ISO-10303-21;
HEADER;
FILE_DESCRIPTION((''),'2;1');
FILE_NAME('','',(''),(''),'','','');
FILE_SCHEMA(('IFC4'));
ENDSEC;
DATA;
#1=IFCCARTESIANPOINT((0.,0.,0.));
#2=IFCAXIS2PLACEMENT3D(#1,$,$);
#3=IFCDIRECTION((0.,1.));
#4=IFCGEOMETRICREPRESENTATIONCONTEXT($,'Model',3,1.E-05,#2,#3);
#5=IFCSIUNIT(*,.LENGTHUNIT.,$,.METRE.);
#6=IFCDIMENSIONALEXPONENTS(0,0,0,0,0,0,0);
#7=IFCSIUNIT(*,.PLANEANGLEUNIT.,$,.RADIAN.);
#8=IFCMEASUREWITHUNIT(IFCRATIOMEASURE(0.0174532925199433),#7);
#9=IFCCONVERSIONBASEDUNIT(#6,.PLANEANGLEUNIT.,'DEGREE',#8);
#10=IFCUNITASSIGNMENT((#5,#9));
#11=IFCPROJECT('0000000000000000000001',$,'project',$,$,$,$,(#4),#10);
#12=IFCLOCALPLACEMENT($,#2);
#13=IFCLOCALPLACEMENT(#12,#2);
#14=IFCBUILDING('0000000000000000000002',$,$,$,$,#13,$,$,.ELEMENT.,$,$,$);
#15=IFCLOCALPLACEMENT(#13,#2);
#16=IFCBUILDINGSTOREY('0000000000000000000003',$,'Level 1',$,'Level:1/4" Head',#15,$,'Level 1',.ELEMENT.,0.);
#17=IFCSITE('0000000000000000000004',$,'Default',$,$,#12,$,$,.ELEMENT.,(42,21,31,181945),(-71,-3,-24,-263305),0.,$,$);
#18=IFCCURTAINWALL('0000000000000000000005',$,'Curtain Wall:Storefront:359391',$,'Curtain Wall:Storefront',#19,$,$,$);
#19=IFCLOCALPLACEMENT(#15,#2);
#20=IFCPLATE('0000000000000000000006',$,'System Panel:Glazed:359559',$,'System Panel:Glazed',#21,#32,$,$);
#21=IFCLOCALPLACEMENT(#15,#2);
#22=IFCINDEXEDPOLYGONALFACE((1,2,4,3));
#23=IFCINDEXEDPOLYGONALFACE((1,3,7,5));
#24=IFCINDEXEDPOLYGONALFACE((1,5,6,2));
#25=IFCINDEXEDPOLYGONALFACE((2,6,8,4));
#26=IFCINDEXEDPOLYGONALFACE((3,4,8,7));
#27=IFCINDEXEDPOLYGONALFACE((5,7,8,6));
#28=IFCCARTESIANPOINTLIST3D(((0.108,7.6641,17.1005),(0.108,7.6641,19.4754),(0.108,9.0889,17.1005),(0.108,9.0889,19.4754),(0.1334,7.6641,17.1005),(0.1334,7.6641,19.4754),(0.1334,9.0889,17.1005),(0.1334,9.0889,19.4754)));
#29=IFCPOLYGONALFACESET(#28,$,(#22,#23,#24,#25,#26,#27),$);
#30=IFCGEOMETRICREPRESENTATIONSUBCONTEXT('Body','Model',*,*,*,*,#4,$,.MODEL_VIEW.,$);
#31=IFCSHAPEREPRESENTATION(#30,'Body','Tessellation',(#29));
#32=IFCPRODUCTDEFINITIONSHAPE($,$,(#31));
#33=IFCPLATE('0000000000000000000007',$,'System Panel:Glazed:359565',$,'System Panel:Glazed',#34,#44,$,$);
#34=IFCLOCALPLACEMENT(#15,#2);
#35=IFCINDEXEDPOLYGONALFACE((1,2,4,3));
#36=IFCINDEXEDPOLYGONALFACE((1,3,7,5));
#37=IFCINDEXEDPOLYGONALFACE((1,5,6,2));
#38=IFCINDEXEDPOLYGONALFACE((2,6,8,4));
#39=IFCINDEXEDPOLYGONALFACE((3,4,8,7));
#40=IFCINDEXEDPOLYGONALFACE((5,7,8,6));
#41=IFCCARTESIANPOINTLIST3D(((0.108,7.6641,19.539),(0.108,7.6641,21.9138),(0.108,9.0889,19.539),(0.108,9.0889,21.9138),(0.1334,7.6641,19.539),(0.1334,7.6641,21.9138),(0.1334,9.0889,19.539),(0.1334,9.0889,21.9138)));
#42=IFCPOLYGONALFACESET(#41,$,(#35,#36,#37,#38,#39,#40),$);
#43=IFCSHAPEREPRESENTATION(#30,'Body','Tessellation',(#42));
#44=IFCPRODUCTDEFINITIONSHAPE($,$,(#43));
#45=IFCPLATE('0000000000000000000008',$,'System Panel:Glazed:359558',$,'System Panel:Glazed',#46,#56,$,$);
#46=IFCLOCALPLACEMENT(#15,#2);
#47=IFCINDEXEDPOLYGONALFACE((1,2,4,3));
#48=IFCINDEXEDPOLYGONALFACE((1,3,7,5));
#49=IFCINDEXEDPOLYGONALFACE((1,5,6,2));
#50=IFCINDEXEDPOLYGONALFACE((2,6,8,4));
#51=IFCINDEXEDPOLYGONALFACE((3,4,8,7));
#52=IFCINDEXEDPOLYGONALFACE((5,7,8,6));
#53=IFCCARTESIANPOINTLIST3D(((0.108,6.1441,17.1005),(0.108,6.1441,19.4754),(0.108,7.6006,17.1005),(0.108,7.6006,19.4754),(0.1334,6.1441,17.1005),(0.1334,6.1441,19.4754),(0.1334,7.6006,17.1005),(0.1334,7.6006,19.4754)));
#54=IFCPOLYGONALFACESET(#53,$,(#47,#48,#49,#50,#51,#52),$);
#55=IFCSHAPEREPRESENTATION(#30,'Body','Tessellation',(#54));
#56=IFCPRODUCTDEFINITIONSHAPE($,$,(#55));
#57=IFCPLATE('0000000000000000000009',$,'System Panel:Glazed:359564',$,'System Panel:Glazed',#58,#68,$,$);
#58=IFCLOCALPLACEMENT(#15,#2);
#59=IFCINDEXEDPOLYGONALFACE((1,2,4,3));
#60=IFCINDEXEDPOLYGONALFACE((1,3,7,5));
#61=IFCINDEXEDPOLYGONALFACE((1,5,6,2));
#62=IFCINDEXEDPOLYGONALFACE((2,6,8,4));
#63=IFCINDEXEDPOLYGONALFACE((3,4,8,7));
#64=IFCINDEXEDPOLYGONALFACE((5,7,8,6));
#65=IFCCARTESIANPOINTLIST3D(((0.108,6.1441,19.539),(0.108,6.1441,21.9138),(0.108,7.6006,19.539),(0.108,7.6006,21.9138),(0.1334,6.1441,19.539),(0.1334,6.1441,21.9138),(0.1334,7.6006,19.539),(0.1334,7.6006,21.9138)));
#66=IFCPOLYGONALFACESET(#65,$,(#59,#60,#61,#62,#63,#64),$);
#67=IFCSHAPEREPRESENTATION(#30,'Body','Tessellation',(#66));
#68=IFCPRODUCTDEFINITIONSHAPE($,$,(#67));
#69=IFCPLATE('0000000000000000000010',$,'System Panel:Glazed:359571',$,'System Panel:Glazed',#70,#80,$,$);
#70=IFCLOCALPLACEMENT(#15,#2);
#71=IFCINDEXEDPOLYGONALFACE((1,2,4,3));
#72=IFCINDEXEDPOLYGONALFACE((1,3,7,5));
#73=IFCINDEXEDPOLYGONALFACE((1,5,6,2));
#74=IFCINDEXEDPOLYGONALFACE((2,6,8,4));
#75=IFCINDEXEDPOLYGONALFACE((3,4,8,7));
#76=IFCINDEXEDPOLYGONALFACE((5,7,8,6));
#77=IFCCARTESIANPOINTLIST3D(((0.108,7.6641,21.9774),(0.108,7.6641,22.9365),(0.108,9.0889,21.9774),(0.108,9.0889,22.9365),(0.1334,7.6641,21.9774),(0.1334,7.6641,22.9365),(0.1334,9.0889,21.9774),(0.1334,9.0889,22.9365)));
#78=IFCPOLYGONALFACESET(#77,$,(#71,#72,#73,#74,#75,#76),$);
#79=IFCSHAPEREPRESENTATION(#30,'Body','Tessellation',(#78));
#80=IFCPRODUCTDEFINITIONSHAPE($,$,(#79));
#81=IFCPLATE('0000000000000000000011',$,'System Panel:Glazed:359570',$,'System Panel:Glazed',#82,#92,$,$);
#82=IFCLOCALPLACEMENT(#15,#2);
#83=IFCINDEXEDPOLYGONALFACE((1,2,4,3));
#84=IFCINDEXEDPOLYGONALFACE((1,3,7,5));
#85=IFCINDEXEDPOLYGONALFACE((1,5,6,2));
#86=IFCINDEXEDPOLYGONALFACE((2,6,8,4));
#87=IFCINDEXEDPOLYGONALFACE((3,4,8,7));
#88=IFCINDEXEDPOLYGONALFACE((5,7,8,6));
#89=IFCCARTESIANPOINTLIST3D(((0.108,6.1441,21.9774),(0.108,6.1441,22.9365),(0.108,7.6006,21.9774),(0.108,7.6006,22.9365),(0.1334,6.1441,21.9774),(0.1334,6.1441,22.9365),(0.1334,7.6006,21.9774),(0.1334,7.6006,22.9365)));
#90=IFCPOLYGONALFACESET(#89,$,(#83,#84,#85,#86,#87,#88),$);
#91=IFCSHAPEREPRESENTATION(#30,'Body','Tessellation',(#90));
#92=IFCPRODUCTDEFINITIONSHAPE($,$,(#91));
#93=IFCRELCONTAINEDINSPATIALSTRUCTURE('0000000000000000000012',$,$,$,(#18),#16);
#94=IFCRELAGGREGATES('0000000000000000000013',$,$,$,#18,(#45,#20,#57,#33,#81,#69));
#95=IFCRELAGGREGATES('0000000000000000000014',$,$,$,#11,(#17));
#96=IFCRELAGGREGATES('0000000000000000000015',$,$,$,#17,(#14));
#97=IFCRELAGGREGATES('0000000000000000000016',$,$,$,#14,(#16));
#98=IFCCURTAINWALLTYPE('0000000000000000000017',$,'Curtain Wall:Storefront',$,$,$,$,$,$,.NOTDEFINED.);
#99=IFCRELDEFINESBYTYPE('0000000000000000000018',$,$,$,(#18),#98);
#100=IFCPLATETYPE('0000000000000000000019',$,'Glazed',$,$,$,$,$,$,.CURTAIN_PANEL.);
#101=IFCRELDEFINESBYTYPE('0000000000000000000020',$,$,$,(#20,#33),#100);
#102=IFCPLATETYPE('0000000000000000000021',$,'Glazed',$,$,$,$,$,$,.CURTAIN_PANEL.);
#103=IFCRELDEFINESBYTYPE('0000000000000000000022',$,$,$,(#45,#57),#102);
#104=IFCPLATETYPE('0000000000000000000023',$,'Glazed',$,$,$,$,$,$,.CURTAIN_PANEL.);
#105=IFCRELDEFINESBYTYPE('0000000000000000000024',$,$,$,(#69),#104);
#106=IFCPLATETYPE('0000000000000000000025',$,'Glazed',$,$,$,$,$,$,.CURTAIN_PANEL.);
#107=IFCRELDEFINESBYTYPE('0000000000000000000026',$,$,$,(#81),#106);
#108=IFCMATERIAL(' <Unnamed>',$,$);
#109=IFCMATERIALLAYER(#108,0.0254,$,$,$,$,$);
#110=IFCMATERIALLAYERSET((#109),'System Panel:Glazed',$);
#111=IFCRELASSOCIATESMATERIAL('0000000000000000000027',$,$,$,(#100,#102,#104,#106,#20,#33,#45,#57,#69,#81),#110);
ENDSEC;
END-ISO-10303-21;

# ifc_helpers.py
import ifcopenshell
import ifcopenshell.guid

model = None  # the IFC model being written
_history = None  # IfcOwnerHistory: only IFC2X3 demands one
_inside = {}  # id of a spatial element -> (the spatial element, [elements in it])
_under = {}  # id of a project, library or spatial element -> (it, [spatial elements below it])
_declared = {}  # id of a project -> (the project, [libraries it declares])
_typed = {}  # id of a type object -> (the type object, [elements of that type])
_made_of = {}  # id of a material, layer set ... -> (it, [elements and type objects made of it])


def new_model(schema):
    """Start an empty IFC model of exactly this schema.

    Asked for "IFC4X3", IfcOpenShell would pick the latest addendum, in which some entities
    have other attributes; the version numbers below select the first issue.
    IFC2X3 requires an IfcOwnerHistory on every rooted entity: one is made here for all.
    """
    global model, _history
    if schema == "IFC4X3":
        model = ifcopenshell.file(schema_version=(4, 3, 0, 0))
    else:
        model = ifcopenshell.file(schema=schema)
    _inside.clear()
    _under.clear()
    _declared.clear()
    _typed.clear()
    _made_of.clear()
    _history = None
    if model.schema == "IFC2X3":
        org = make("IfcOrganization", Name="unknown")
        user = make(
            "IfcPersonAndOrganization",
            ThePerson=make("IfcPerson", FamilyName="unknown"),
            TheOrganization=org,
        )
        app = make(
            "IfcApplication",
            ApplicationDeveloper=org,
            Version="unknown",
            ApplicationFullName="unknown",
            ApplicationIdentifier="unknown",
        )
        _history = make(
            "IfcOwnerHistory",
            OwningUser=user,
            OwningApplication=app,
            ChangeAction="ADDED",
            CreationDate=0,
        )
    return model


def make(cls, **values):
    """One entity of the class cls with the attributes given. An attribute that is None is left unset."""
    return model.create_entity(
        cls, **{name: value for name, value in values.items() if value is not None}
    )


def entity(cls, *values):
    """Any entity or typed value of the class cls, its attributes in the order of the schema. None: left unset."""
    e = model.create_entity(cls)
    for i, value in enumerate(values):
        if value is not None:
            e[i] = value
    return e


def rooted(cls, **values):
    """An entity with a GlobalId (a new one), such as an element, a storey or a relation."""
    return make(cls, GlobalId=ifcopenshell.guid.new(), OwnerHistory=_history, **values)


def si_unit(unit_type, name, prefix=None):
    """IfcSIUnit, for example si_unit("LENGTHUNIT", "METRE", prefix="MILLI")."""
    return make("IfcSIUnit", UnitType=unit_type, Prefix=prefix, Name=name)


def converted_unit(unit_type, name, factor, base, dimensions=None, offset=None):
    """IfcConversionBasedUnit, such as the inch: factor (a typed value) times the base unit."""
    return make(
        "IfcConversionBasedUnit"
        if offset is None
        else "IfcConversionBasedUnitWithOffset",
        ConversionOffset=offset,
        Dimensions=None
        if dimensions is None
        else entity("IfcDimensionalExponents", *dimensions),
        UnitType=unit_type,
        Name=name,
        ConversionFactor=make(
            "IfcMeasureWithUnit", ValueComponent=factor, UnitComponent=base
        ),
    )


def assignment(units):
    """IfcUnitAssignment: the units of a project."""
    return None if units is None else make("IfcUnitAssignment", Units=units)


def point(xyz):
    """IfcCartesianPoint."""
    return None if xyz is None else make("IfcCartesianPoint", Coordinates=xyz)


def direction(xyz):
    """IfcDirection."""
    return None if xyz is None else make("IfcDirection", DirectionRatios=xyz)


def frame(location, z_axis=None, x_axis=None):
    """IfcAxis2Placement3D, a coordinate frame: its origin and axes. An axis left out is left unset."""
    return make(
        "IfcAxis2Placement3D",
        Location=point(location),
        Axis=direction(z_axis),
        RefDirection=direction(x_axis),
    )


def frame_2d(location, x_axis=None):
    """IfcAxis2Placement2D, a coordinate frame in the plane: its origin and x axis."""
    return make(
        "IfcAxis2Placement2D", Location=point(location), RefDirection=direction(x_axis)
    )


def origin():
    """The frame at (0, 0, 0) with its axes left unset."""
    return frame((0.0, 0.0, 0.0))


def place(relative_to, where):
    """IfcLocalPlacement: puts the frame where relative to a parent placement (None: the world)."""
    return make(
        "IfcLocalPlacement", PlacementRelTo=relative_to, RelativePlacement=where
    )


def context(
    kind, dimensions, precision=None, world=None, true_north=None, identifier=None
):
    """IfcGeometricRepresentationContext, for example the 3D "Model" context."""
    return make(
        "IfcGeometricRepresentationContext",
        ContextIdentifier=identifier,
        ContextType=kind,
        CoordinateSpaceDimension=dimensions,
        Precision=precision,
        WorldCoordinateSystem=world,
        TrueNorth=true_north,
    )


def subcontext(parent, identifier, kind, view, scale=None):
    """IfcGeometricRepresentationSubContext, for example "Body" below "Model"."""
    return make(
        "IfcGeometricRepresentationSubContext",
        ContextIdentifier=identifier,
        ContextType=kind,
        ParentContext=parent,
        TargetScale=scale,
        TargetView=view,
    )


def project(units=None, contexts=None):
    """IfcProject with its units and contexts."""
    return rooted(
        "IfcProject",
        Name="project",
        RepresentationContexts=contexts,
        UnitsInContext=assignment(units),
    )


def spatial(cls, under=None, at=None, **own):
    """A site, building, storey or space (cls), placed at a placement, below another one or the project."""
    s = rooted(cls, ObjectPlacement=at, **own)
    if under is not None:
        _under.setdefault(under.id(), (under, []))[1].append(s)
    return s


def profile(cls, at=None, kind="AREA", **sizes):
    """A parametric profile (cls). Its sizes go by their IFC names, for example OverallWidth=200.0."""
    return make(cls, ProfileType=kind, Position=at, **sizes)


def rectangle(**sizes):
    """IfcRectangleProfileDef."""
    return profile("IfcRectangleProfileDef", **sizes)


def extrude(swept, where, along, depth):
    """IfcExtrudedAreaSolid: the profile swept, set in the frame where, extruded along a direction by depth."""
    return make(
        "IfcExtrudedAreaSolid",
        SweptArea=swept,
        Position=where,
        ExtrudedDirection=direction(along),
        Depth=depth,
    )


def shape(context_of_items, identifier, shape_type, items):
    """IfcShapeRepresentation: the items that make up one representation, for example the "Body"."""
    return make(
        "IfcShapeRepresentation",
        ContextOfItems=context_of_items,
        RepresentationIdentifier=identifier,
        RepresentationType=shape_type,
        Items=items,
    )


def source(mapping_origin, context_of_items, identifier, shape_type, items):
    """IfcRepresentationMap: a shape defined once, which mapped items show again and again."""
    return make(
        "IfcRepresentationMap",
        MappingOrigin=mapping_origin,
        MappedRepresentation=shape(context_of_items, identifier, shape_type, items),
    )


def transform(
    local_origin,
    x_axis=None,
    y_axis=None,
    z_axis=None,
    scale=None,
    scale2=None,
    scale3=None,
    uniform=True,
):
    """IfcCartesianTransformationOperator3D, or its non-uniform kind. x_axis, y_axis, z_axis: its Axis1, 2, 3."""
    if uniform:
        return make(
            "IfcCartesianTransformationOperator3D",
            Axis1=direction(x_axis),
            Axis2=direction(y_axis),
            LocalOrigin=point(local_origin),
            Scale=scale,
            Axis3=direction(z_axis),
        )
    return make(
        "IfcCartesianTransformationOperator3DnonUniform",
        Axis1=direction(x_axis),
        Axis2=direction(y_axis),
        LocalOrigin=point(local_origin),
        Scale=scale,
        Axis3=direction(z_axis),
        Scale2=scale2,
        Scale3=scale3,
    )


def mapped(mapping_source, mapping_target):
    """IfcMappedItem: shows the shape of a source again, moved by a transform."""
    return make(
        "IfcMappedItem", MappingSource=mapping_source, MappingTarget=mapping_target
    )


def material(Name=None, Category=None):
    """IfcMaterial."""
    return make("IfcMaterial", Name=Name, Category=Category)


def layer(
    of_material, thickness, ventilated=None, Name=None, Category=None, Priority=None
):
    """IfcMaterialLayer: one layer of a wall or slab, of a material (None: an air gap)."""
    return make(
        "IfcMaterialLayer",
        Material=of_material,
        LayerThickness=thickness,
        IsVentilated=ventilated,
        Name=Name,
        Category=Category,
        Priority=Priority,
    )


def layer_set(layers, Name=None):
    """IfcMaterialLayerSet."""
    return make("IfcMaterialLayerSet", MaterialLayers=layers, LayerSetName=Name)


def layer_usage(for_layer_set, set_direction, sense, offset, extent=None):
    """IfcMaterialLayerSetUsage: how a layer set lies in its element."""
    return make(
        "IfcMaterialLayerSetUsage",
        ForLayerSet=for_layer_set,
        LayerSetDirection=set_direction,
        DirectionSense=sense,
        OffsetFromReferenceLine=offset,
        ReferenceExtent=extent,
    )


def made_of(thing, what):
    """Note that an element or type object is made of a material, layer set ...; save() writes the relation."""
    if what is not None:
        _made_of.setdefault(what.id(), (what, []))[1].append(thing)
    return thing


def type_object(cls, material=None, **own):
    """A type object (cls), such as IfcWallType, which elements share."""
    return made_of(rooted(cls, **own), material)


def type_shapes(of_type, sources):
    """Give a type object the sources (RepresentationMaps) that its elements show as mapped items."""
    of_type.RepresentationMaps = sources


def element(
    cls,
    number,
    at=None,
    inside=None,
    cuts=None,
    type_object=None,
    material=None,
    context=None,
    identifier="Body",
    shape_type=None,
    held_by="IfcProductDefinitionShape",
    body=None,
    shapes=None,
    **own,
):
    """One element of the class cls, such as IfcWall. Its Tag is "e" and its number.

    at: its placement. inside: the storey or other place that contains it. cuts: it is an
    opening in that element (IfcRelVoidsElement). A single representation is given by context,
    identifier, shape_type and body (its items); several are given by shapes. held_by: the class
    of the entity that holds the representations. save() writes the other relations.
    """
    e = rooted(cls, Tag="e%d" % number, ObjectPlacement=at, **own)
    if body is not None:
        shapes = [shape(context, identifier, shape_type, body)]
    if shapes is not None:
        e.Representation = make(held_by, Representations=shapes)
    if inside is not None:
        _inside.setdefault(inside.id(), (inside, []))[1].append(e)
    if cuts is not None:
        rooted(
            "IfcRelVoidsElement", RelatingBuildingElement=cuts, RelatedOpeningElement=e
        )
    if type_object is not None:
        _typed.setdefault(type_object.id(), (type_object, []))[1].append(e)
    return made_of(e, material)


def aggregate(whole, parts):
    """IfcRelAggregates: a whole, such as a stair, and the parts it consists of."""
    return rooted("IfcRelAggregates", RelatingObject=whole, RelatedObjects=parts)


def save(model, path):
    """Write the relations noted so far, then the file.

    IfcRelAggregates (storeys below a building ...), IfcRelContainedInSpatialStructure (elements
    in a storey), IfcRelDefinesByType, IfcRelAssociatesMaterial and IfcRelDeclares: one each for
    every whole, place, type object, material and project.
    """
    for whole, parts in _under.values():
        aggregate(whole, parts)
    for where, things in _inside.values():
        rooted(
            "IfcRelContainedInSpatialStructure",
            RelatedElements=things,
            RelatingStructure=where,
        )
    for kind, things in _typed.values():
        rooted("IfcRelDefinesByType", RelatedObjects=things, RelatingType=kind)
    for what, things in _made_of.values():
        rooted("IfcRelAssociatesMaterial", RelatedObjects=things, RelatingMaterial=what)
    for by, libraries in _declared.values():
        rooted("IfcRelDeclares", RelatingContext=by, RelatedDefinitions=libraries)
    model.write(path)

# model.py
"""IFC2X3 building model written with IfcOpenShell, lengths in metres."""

from ifc_helpers import new_model, entity, si_unit, converted_unit, direction, frame, frame_2d, origin, place, context, subcontext, project, spatial, rectangle, extrude, source, transform, mapped, material, layer, layer_set, layer_usage, type_object, type_shapes, element, aggregate, save


model = new_model("IFC2X3")

# Units and contexts
model_context = context("Model", 3, precision=1e-05, world=origin(), true_north=direction((0.0, 1.0)))
body_context = subcontext(model_context, "Body", "Model", "MODEL_VIEW")
ifc_project = project(units=[si_unit("LENGTHUNIT", "METRE"), converted_unit("PLANEANGLEUNIT", "DEGREE", entity("IfcRatioMeasure", 0.0174532925199433), si_unit("PLANEANGLEUNIT", "RADIAN"), dimensions=[0, 0, 0, 0, 0, 0, 0])], contexts=[model_context])

# Site, building, storey
site_placement = place(None, origin())
site = spatial("IfcSite", under=ifc_project, at=site_placement, Name="Default", CompositionType="ELEMENT", RefLatitude=(42, 21, 31, 181945), RefLongitude=(-71, -3, -24, -263305), RefElevation=0.0)
building_placement = place(site_placement, origin())
building = spatial("IfcBuilding", under=site, at=building_placement, CompositionType="ELEMENT")
storey_placement = place(building_placement, origin())
storey = spatial("IfcBuildingStorey", under=building, at=storey_placement, Name="Level 1", ObjectType="Level:1/4\" Head", LongName="Level 1", CompositionType="ELEMENT", Elevation=0.0)

# Curtain wall, plates
curtain_wall_type = type_object("IfcCurtainWallType", Name="Curtain Wall:Storefront", PredefinedType="NOTDEFINED")
curtain_wall_placement = place(storey_placement, origin())
curtain_wall = element("IfcCurtainWall", 1, at=curtain_wall_placement, inside=storey, type_object=curtain_wall_type, Name="Curtain Wall:Storefront:359391", ObjectType="Curtain Wall:Storefront")
ifc_material_1 = material(Name=" <Unnamed>")
ifc_layer = layer(ifc_material_1, 0.0254)
ifc_layer_set = layer_set([ifc_layer], Name="System Panel:Glazed")
ifc_layer_usage_1 = layer_usage(ifc_layer_set, "AXIS3", "POSITIVE", 0.1042)
plate_type_1 = type_object("IfcPlateType", Name="Glazed", PredefinedType="CURTAIN_PANEL", material=ifc_layer_set)
shared_shape_1 = source(origin(), body_context, "Body", "SweptSolid", [
    extrude(rectangle(XDim=0.0254, YDim=1.4248, at=frame_2d((0.0, 0.0), x_axis=(1.0, 0.0))), frame((0.7124, 0.0127, 0.0), z_axis=(0.0, 0.0, 1.0), x_axis=(0.0, 1.0, 0.0)), (0.0, 0.0, 1.0), 2.3749),
])
type_shapes(plate_type_1, [shared_shape_1])
plate_1_placement = place(curtain_wall_placement, frame((0.1334, 7.6641, 17.1005), z_axis=(0.0, 0.0, 1.0), x_axis=(0.0, 1.0, 0.0)))
plate_1 = element("IfcPlate", 2, at=plate_1_placement, type_object=plate_type_1, material=ifc_layer_usage_1, Name="System Panel:Glazed:359559", ObjectType="System Panel:Glazed", context=body_context, shape_type="MappedRepresentation", body=[
    mapped(shared_shape_1, transform((0.0, 0.0, 0.0), scale=1.0)),
])
ifc_layer_usage_2 = layer_usage(ifc_layer_set, "AXIS3", "POSITIVE", 0.1042)
plate_2_placement = place(curtain_wall_placement, frame((0.1334, 7.6641, 19.5389), z_axis=(0.0, 0.0, 1.0), x_axis=(0.0, 1.0, 0.0)))
plate_2 = element("IfcPlate", 3, at=plate_2_placement, type_object=plate_type_1, material=ifc_layer_usage_2, Name="System Panel:Glazed:359565", ObjectType="System Panel:Glazed", context=body_context, shape_type="MappedRepresentation", body=[
    mapped(shared_shape_1, transform((0.0, 0.0, 0.0), scale=1.0)),
])
ifc_layer_usage_3 = layer_usage(ifc_layer_set, "AXIS3", "POSITIVE", 0.1042)
plate_type_2 = type_object("IfcPlateType", Name="Glazed", PredefinedType="CURTAIN_PANEL", material=ifc_layer_set)
shared_shape_2 = source(origin(), body_context, "Body", "SweptSolid", [
    extrude(rectangle(XDim=0.0254, YDim=1.4565, at=frame_2d((0.0, 0.0), x_axis=(1.0, 0.0))), frame((0.7282, 0.0127, 0.0), z_axis=(0.0, 0.0, 1.0), x_axis=(0.0, 1.0, 0.0)), (0.0, 0.0, 1.0), 2.3749),
])
type_shapes(plate_type_2, [shared_shape_2])
plate_3_placement = place(curtain_wall_placement, frame((0.1334, 6.1441, 17.1005), z_axis=(0.0, 0.0, 1.0), x_axis=(0.0, 1.0, 0.0)))
plate_3 = element("IfcPlate", 4, at=plate_3_placement, type_object=plate_type_2, material=ifc_layer_usage_3, Name="System Panel:Glazed:359558", ObjectType="System Panel:Glazed", context=body_context, shape_type="MappedRepresentation", body=[
    mapped(shared_shape_2, transform((0.0, 0.0, 0.0), scale=1.0)),
])
ifc_layer_usage_4 = layer_usage(ifc_layer_set, "AXIS3", "POSITIVE", 0.1042)
plate_4_placement = place(curtain_wall_placement, frame((0.1334, 6.1441, 19.5389), z_axis=(0.0, 0.0, 1.0), x_axis=(0.0, 1.0, 0.0)))
plate_4 = element("IfcPlate", 5, at=plate_4_placement, type_object=plate_type_2, material=ifc_layer_usage_4, Name="System Panel:Glazed:359564", ObjectType="System Panel:Glazed", context=body_context, shape_type="MappedRepresentation", body=[
    mapped(shared_shape_2, transform((0.0, 0.0, 0.0), scale=1.0)),
])
ifc_layer_usage_5 = layer_usage(ifc_layer_set, "AXIS3", "POSITIVE", 0.1042)
plate_type_3 = type_object("IfcPlateType", Name="Glazed", PredefinedType="CURTAIN_PANEL", material=ifc_layer_set)
shared_shape_3 = source(origin(), body_context, "Body", "SweptSolid", [
    extrude(rectangle(XDim=0.0254, YDim=1.4248, at=frame_2d((0.0, 0.0), x_axis=(1.0, 0.0))), frame((0.7124, 0.0127, 0.0), z_axis=(0.0, 0.0, 1.0), x_axis=(0.0, 1.0, 0.0)), (0.0, 0.0, 1.0), 0.9592),
])
type_shapes(plate_type_3, [shared_shape_3])
plate_5_placement = place(curtain_wall_placement, frame((0.1334, 7.6641, 21.9774), z_axis=(0.0, 0.0, 1.0), x_axis=(0.0, 1.0, 0.0)))
plate_5 = element("IfcPlate", 6, at=plate_5_placement, type_object=plate_type_3, material=ifc_layer_usage_5, Name="System Panel:Glazed:359571", ObjectType="System Panel:Glazed", context=body_context, shape_type="MappedRepresentation", body=[
    mapped(shared_shape_3, transform((0.0, 0.0, 0.0), scale=1.0)),
])
ifc_layer_usage_6 = layer_usage(ifc_layer_set, "AXIS3", "POSITIVE", 0.1042)
plate_type_4 = type_object("IfcPlateType", Name="Glazed", PredefinedType="CURTAIN_PANEL", material=ifc_layer_set)
shared_shape_4 = source(origin(), body_context, "Body", "SweptSolid", [
    extrude(rectangle(XDim=0.0254, YDim=1.4565, at=frame_2d((0.0, 0.0), x_axis=(1.0, 0.0))), frame((0.7282, 0.0127, 0.0), z_axis=(0.0, 0.0, 1.0), x_axis=(0.0, 1.0, 0.0)), (0.0, 0.0, 1.0), 0.9592),
])
type_shapes(plate_type_4, [shared_shape_4])
plate_6_placement = place(curtain_wall_placement, frame((0.1334, 6.1441, 21.9774), z_axis=(0.0, 0.0, 1.0), x_axis=(0.0, 1.0, 0.0)))
plate_6 = element("IfcPlate", 7, at=plate_6_placement, type_object=plate_type_4, material=ifc_layer_usage_6, Name="System Panel:Glazed:359570", ObjectType="System Panel:Glazed", context=body_context, shape_type="MappedRepresentation", body=[
    mapped(shared_shape_4, transform((0.0, 0.0, 0.0), scale=1.0)),
])
aggregate(curtain_wall, [plate_3, plate_1, plate_4, plate_2, plate_6, plate_5])

save(model, "model.ifc")
